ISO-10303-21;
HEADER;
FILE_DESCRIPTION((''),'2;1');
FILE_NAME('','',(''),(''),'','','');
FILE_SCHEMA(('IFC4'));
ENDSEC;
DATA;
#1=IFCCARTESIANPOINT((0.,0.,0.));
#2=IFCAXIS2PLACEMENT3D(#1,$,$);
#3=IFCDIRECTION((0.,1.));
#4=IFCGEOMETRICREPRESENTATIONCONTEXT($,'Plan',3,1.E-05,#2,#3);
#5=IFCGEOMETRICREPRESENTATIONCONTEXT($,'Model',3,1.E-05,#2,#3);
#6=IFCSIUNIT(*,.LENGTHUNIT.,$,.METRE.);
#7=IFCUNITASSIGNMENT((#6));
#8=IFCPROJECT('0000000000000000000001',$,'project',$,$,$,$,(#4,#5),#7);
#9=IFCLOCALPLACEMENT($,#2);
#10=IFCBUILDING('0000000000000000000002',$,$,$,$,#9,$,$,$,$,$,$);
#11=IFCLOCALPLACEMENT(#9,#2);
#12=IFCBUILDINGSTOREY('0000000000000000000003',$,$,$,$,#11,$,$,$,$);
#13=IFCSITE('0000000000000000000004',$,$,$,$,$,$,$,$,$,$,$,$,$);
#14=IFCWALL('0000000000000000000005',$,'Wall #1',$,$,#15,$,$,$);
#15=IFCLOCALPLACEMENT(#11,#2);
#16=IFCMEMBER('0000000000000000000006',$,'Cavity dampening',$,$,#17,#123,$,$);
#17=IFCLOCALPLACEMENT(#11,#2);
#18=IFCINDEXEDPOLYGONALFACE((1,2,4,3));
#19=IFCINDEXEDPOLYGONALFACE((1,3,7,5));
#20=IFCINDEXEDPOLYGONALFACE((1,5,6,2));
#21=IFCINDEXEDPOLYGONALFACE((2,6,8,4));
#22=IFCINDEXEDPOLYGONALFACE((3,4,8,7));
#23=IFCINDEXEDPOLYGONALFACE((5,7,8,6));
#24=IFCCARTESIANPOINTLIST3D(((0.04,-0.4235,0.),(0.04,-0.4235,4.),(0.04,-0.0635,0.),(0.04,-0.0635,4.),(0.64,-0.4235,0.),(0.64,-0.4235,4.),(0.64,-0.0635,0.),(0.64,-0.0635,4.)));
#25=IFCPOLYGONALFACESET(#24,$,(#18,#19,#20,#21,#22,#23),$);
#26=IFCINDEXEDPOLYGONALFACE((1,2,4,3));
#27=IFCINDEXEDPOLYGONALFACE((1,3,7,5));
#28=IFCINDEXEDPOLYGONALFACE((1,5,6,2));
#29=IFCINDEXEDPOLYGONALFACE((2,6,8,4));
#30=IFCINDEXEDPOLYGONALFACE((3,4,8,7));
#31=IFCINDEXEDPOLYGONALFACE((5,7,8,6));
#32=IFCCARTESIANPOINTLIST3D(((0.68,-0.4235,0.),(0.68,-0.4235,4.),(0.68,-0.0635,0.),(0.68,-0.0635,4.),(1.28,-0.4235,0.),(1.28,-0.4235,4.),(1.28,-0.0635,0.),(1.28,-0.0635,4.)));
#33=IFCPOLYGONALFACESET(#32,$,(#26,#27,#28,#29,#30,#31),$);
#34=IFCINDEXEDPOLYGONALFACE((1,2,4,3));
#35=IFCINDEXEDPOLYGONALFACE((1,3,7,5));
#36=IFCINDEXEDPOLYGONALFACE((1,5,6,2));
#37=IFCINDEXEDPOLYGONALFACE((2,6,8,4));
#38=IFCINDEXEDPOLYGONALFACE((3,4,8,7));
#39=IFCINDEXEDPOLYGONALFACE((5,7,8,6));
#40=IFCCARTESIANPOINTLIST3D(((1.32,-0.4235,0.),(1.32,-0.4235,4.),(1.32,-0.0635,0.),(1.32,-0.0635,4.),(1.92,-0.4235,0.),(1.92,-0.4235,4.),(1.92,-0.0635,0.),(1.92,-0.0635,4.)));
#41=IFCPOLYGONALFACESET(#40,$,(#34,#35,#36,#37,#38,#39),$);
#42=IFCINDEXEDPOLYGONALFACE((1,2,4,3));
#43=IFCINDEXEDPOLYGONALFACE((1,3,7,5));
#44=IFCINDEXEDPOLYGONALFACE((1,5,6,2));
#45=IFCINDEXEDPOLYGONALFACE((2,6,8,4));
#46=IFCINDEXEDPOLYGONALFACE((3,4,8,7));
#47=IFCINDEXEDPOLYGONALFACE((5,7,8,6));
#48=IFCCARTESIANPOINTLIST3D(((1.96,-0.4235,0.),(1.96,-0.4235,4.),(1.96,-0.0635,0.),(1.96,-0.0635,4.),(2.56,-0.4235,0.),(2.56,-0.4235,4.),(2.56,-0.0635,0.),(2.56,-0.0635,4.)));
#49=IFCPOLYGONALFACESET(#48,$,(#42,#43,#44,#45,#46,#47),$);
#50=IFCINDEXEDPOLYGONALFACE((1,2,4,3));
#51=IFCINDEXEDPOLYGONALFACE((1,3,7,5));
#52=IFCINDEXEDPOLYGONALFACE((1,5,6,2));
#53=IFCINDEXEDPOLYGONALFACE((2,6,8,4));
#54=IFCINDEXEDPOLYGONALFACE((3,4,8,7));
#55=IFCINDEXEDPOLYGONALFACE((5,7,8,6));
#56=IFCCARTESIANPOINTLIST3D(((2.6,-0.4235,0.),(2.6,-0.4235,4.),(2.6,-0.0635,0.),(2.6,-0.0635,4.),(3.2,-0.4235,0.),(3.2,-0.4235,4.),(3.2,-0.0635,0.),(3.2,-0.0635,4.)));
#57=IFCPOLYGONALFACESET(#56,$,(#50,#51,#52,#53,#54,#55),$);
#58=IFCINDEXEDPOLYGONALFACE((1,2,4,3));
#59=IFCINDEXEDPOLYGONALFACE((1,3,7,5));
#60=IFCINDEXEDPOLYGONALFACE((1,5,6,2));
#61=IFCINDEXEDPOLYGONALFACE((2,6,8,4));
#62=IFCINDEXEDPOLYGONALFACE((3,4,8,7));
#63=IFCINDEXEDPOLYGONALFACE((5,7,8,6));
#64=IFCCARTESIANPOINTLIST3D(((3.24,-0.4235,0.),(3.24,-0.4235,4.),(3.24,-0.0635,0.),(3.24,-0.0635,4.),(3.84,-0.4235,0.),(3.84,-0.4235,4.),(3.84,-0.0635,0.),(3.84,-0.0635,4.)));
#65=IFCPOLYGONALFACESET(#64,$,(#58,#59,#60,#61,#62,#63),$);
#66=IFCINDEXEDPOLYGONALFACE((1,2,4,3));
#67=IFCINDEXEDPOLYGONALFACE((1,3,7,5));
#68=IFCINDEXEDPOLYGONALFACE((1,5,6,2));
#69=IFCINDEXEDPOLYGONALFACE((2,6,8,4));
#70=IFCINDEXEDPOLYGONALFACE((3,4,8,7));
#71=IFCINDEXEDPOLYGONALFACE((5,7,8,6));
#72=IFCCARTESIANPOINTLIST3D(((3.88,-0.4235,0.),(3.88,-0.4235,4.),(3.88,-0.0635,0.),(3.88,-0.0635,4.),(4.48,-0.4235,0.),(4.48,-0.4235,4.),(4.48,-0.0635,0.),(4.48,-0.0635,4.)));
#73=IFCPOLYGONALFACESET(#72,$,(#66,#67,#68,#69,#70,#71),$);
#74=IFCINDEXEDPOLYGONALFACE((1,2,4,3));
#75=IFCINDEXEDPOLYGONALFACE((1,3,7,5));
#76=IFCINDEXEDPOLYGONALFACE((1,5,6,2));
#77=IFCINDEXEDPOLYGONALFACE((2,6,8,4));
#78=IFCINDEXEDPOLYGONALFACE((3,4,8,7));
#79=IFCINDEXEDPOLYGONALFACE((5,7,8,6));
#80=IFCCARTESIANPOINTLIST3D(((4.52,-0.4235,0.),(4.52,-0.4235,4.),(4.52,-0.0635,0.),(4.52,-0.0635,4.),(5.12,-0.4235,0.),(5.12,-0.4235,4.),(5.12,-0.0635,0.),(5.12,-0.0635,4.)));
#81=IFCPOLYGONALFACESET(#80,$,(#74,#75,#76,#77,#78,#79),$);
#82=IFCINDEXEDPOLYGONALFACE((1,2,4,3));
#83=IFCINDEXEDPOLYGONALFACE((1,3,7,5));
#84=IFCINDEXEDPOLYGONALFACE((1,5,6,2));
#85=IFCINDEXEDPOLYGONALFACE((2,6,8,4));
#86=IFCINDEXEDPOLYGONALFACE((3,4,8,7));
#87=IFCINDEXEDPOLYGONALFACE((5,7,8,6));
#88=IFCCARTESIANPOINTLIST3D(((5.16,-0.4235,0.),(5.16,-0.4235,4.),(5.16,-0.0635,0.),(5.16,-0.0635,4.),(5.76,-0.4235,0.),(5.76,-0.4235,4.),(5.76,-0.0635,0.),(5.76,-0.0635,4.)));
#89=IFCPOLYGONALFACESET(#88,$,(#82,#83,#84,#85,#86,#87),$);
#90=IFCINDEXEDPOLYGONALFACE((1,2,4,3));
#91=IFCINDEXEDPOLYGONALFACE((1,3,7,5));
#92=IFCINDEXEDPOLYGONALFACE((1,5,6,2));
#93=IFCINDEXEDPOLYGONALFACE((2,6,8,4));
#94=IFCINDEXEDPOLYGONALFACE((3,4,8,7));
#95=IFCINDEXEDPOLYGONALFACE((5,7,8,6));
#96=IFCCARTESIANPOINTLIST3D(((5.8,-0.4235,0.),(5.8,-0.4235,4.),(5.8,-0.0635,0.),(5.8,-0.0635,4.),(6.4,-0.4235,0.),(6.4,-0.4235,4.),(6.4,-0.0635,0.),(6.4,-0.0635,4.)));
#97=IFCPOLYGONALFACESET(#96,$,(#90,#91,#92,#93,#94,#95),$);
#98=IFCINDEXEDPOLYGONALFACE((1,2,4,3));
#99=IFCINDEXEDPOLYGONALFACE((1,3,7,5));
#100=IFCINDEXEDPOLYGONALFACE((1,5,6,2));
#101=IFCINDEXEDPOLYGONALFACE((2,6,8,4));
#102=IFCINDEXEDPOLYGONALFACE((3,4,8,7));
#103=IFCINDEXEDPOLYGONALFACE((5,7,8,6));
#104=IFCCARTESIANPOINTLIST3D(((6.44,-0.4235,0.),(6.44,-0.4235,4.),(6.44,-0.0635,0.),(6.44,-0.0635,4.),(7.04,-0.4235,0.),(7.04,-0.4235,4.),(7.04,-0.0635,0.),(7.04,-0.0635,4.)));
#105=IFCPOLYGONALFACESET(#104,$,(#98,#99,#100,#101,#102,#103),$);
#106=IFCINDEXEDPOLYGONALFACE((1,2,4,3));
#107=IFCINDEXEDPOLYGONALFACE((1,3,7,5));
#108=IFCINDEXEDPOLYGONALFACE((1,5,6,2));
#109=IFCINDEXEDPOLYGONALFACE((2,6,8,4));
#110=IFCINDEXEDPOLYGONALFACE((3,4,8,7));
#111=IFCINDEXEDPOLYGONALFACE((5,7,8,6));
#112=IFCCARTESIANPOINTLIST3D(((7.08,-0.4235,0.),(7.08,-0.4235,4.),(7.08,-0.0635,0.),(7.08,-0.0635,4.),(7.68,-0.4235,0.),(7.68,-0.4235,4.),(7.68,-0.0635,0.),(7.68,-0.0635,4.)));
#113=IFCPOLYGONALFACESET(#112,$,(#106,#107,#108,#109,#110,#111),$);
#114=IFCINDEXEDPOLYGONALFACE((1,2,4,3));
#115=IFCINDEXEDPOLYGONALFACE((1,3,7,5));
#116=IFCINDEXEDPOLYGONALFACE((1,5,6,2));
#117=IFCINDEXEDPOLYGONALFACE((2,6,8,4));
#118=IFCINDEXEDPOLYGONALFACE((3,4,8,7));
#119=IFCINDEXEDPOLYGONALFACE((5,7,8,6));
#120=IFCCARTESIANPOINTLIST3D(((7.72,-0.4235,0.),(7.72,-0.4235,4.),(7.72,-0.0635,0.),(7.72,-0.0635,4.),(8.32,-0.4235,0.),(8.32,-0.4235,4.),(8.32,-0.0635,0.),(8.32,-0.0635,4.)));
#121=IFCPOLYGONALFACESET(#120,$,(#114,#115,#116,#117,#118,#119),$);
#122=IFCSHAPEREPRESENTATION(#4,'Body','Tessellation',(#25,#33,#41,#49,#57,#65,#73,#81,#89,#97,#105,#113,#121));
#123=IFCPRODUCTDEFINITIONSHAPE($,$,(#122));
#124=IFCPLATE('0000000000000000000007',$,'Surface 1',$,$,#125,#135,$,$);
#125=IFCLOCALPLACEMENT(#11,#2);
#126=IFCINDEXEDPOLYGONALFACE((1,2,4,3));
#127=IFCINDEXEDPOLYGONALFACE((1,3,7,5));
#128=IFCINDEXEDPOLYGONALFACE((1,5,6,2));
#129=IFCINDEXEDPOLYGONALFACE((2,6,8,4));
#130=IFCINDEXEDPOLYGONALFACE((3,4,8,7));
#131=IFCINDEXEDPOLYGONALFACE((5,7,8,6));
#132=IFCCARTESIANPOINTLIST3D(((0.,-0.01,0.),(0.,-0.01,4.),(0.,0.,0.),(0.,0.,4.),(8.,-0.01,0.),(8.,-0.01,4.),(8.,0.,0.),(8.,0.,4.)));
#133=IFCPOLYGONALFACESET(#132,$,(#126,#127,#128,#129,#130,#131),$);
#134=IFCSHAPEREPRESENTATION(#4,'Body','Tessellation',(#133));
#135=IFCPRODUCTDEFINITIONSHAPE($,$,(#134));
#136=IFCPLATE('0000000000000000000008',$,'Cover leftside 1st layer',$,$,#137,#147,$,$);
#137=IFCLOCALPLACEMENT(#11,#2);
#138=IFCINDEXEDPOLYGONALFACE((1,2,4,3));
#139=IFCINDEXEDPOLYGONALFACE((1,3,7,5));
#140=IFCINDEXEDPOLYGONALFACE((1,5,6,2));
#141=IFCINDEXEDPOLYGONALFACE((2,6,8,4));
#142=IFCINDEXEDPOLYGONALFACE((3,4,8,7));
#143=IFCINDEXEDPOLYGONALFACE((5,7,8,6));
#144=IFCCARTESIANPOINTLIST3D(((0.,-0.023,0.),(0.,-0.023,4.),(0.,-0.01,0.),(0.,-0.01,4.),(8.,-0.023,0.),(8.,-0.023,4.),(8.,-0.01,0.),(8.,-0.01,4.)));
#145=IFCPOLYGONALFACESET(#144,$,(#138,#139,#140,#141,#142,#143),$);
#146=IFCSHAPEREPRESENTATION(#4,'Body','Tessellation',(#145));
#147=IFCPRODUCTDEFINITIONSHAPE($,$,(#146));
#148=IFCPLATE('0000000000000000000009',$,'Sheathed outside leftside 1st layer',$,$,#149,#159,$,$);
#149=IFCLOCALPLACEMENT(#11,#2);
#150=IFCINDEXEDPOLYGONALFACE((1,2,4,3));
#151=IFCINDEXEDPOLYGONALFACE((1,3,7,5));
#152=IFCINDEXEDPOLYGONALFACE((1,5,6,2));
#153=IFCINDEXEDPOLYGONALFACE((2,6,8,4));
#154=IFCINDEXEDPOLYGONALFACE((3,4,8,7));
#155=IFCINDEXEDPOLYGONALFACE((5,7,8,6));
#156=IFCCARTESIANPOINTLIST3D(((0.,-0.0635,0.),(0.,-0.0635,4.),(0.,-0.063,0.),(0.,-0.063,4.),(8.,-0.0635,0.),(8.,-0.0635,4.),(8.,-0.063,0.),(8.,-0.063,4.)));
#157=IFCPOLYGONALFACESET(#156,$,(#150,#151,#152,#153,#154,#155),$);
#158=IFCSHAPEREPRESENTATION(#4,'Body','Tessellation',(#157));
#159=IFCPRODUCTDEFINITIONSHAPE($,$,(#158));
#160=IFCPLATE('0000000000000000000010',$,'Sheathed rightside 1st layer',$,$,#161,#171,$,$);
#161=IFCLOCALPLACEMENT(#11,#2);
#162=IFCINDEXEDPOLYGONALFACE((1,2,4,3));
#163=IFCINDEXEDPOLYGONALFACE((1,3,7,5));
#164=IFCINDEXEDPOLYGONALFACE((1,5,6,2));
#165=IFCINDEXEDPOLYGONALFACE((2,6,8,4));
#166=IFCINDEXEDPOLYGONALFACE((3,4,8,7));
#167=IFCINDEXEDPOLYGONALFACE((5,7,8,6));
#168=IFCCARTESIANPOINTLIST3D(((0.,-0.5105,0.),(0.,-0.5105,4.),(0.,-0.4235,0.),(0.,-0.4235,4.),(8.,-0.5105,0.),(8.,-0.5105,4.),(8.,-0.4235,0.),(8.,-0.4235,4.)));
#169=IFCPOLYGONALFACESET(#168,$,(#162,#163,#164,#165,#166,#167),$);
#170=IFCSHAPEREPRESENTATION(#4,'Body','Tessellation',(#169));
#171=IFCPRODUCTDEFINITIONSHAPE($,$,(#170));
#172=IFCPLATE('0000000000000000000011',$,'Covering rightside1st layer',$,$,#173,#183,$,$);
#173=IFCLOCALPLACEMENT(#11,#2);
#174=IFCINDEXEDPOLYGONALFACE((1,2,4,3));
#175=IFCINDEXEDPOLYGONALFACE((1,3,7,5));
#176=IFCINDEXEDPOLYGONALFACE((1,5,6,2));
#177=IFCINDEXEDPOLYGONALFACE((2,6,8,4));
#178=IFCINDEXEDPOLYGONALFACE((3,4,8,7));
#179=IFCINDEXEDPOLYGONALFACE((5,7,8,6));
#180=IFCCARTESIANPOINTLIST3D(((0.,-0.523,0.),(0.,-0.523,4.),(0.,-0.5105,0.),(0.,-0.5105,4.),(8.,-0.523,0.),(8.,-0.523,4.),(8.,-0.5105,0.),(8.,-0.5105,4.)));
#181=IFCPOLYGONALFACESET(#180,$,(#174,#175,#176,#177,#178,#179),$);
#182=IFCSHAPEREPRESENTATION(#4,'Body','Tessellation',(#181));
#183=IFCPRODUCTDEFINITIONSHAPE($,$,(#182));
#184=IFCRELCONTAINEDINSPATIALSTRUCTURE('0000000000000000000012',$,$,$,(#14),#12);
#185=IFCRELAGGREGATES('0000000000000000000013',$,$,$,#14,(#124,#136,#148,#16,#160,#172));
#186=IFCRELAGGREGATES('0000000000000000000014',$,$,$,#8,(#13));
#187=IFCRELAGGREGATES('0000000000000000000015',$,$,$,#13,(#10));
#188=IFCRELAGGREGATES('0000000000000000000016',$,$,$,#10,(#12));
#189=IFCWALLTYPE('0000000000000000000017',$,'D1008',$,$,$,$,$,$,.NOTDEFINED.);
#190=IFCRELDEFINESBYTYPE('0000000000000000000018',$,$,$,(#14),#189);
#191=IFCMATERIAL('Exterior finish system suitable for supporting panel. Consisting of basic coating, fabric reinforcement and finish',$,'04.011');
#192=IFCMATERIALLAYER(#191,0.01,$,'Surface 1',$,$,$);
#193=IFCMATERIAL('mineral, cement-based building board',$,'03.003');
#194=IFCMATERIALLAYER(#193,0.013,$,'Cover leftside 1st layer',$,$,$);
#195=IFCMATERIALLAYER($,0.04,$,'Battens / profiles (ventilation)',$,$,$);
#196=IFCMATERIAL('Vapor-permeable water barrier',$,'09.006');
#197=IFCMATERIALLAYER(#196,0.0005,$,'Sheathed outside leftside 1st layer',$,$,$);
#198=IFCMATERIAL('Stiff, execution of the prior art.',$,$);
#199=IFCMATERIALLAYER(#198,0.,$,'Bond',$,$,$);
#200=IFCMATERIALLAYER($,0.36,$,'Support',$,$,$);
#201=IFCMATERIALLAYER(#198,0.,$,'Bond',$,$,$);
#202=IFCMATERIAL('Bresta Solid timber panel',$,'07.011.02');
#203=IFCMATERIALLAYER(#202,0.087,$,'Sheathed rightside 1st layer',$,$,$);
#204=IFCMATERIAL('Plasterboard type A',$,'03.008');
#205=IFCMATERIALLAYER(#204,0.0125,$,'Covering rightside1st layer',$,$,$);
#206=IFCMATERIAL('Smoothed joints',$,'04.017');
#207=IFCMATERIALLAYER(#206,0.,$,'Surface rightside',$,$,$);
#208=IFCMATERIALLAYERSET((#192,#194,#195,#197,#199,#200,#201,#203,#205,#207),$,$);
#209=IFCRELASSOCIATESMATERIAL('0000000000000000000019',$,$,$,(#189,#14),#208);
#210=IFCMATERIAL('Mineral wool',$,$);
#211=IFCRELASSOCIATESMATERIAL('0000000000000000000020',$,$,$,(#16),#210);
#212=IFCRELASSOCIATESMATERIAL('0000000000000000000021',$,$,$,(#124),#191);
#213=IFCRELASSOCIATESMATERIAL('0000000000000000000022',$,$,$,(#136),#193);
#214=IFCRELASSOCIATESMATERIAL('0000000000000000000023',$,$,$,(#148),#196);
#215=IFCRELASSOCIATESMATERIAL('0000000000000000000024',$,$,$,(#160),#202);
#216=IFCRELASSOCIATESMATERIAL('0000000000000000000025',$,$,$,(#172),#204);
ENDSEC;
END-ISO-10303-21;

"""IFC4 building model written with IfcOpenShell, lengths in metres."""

from ifc_helpers import new_model, si_unit, direction, frame, frame_2d, origin, origin_with_axes, place, context, project, spatial, rectangle, extrude, material, layer, layer_set, type_object, element, aggregate, save


model = new_model("IFC4")

# Units and contexts
plan_context = context("Plan", 3, precision=1e-05, world=origin(), true_north=direction((0.0, 1.0)))
model_context = context("Model", 3, precision=1e-05, world=origin(), true_north=direction((0.0, 1.0)))
ifc_project = project(units=[si_unit("LENGTHUNIT", "METRE")], contexts=[plan_context, model_context])

# Site, building, storey
site = spatial("IfcSite", under=ifc_project)
building_placement = place(None, origin())
building = spatial("IfcBuilding", under=site, at=building_placement)
storey_placement = place(building_placement, origin())
storey = spatial("IfcBuildingStorey", under=building, at=storey_placement)

# Wall, member, plates
ifc_material_1 = material(Name="Exterior finish system suitable for supporting panel. Consisting of basic coating, fabric reinforcement and finish", Category="04.011")
ifc_layer_1 = layer(ifc_material_1, 0.01, Name="Surface 1")
ifc_material_2 = material(Name="mineral, cement-based building board", Category="03.003")
ifc_layer_2 = layer(ifc_material_2, 0.013, Name="Cover leftside 1st layer")
ifc_layer_3 = layer(None, 0.04, Name="Battens / profiles (ventilation)")
ifc_material_3 = material(Name="Vapor-permeable water barrier", Category="09.006")
ifc_layer_4 = layer(ifc_material_3, 0.0005, Name="Sheathed outside leftside 1st layer")
ifc_material_4 = material(Name="Stiff, execution of the prior art.")
ifc_layer_5 = layer(ifc_material_4, 0.0, Name="Bond")
ifc_layer_6 = layer(None, 0.36, Name="Support")
ifc_layer_7 = layer(ifc_material_4, 0.0, Name="Bond")
ifc_material_5 = material(Name="Bresta Solid timber panel", Category="07.011.02")
ifc_layer_8 = layer(ifc_material_5, 0.087, Name="Sheathed rightside 1st layer")
ifc_material_6 = material(Name="Plasterboard type A", Category="03.008")
ifc_layer_9 = layer(ifc_material_6, 0.0125, Name="Covering rightside1st layer")
ifc_material_7 = material(Name="Smoothed joints", Category="04.017")
ifc_layer_10 = layer(ifc_material_7, 0.0, Name="Surface rightside")
ifc_layer_set = layer_set([ifc_layer_1, ifc_layer_2, ifc_layer_3, ifc_layer_4, ifc_layer_5, ifc_layer_6, ifc_layer_7, ifc_layer_8, ifc_layer_9, ifc_layer_10])
wall_type = type_object("IfcWallType", Name="D1008", PredefinedType="NOTDEFINED", material=ifc_layer_set)
wall_placement = place(None, frame((0.0, 0.0, 0.0), z_axis=(0.0, -1.0, 0.0), x_axis=(1.0, 0.0, 0.0)))
wall = element("IfcWall", 1, at=wall_placement, inside=storey, type_object=wall_type, material=ifc_layer_set, Name="Wall #1")
ifc_material_8 = material(Name="Mineral wool")
member_1_placement = place(wall_placement, origin())
member_1 = element("IfcMember", 2, at=member_1_placement, material=ifc_material_8, Name="Cavity dampening", context=plan_context, shape_type="SweptSolid", body=[
    extrude(rectangle(XDim=0.6, YDim=0.36, at=frame_2d((0.3, 0.18), x_axis=(1.0, 0.0))), frame((0.04, 4.0, 0.0635), z_axis=(0.0, -1.0, 0.0), x_axis=(1.0, 0.0, 0.0)), (0.0, 0.0, 1.0), 4.0),
    extrude(rectangle(XDim=0.6, YDim=0.36, at=frame_2d((0.3, 0.18), x_axis=(1.0, 0.0))), frame((0.68, 4.0, 0.0635), z_axis=(0.0, -1.0, 0.0), x_axis=(1.0, 0.0, 0.0)), (0.0, 0.0, 1.0), 4.0),
    extrude(rectangle(XDim=0.6, YDim=0.36, at=frame_2d((0.3, 0.18), x_axis=(1.0, 0.0))), frame((1.32, 4.0, 0.0635), z_axis=(0.0, -1.0, 0.0), x_axis=(1.0, 0.0, 0.0)), (0.0, 0.0, 1.0), 4.0),
    extrude(rectangle(XDim=0.6, YDim=0.36, at=frame_2d((0.3, 0.18), x_axis=(1.0, 0.0))), frame((1.96, 4.0, 0.0635), z_axis=(0.0, -1.0, 0.0), x_axis=(1.0, 0.0, 0.0)), (0.0, 0.0, 1.0), 4.0),
    extrude(rectangle(XDim=0.6, YDim=0.36, at=frame_2d((0.3, 0.18), x_axis=(1.0, 0.0))), frame((2.6, 4.0, 0.0635), z_axis=(0.0, -1.0, 0.0), x_axis=(1.0, 0.0, 0.0)), (0.0, 0.0, 1.0), 4.0),
    extrude(rectangle(XDim=0.6, YDim=0.36, at=frame_2d((0.3, 0.18), x_axis=(1.0, 0.0))), frame((3.24, 4.0, 0.0635), z_axis=(0.0, -1.0, 0.0), x_axis=(1.0, 0.0, 0.0)), (0.0, 0.0, 1.0), 4.0),
    extrude(rectangle(XDim=0.6, YDim=0.36, at=frame_2d((0.3, 0.18), x_axis=(1.0, 0.0))), frame((3.88, 4.0, 0.0635), z_axis=(0.0, -1.0, 0.0), x_axis=(1.0, 0.0, 0.0)), (0.0, 0.0, 1.0), 4.0),
    extrude(rectangle(XDim=0.6, YDim=0.36, at=frame_2d((0.3, 0.18), x_axis=(1.0, 0.0))), frame((4.52, 4.0, 0.0635), z_axis=(0.0, -1.0, 0.0), x_axis=(1.0, 0.0, 0.0)), (0.0, 0.0, 1.0), 4.0),
    extrude(rectangle(XDim=0.6, YDim=0.36, at=frame_2d((0.3, 0.18), x_axis=(1.0, 0.0))), frame((5.16, 4.0, 0.0635), z_axis=(0.0, -1.0, 0.0), x_axis=(1.0, 0.0, 0.0)), (0.0, 0.0, 1.0), 4.0),
    extrude(rectangle(XDim=0.6, YDim=0.36, at=frame_2d((0.3, 0.18), x_axis=(1.0, 0.0))), frame((5.8, 4.0, 0.0635), z_axis=(0.0, -1.0, 0.0), x_axis=(1.0, 0.0, 0.0)), (0.0, 0.0, 1.0), 4.0),
    extrude(rectangle(XDim=0.6, YDim=0.36, at=frame_2d((0.3, 0.18), x_axis=(1.0, 0.0))), frame((6.44, 4.0, 0.0635), z_axis=(0.0, -1.0, 0.0), x_axis=(1.0, 0.0, 0.0)), (0.0, 0.0, 1.0), 4.0),
    extrude(rectangle(XDim=0.6, YDim=0.36, at=frame_2d((0.3, 0.18), x_axis=(1.0, 0.0))), frame((7.08, 4.0, 0.0635), z_axis=(0.0, -1.0, 0.0), x_axis=(1.0, 0.0, 0.0)), (0.0, 0.0, 1.0), 4.0),
    extrude(rectangle(XDim=0.6, YDim=0.36, at=frame_2d((0.3, 0.18), x_axis=(1.0, 0.0))), frame((7.72, 4.0, 0.0635), z_axis=(0.0, -1.0, 0.0), x_axis=(1.0, 0.0, 0.0)), (0.0, 0.0, 1.0), 4.0),
])
plate_1_placement = place(wall_placement, origin())
plate_1 = element("IfcPlate", 3, at=plate_1_placement, material=ifc_material_1, Name="Surface 1", context=plan_context, shape_type="SweptSolid", body=[
    extrude(rectangle(XDim=8.0, YDim=4.0, at=frame_2d((4.0, 2.0), x_axis=(1.0, 0.0))), origin_with_axes(), (0.0, 0.0, 1.0), 0.01),
])
plate_2_placement = place(wall_placement, origin())
plate_2 = element("IfcPlate", 4, at=plate_2_placement, material=ifc_material_2, Name="Cover leftside 1st layer", context=plan_context, shape_type="SweptSolid", body=[
    extrude(rectangle(XDim=8.0, YDim=4.0, at=frame_2d((4.0, 2.0), x_axis=(1.0, 0.0))), frame((0.0, 0.0, 0.01), z_axis=(0.0, 0.0, 1.0), x_axis=(1.0, 0.0, 0.0)), (0.0, 0.0, 1.0), 0.013),
])
plate_3_placement = place(wall_placement, origin())
plate_3 = element("IfcPlate", 5, at=plate_3_placement, material=ifc_material_3, Name="Sheathed outside leftside 1st layer", context=plan_context, shape_type="SweptSolid", body=[
    extrude(rectangle(XDim=8.0, YDim=4.0, at=frame_2d((4.0, 2.0), x_axis=(1.0, 0.0))), frame((0.0, 0.0, 0.063), z_axis=(0.0, 0.0, 1.0), x_axis=(1.0, 0.0, 0.0)), (0.0, 0.0, 1.0), 0.0005),
])
plate_4_placement = place(wall_placement, origin())
plate_4 = element("IfcPlate", 6, at=plate_4_placement, material=ifc_material_5, Name="Sheathed rightside 1st layer", context=plan_context, shape_type="SweptSolid", body=[
    extrude(rectangle(XDim=8.0, YDim=4.0, at=frame_2d((4.0, 2.0), x_axis=(1.0, 0.0))), frame((0.0, 0.0, 0.4235), z_axis=(0.0, 0.0, 1.0), x_axis=(1.0, 0.0, 0.0)), (0.0, 0.0, 1.0), 0.087),
])
plate_5_placement = place(wall_placement, origin())
plate_5 = element("IfcPlate", 7, at=plate_5_placement, material=ifc_material_6, Name="Covering rightside1st layer", context=plan_context, shape_type="SweptSolid", body=[
    extrude(rectangle(XDim=8.0, YDim=4.0, at=frame_2d((4.0, 2.0), x_axis=(1.0, 0.0))), frame((0.0, 0.0, 0.5105), z_axis=(0.0, 0.0, 1.0), x_axis=(1.0, 0.0, 0.0)), (0.0, 0.0, 1.0), 0.0125),
])
aggregate(wall, [plate_1, plate_2, plate_3, member_1, plate_4, plate_5])

save(model, "model.ifc")
